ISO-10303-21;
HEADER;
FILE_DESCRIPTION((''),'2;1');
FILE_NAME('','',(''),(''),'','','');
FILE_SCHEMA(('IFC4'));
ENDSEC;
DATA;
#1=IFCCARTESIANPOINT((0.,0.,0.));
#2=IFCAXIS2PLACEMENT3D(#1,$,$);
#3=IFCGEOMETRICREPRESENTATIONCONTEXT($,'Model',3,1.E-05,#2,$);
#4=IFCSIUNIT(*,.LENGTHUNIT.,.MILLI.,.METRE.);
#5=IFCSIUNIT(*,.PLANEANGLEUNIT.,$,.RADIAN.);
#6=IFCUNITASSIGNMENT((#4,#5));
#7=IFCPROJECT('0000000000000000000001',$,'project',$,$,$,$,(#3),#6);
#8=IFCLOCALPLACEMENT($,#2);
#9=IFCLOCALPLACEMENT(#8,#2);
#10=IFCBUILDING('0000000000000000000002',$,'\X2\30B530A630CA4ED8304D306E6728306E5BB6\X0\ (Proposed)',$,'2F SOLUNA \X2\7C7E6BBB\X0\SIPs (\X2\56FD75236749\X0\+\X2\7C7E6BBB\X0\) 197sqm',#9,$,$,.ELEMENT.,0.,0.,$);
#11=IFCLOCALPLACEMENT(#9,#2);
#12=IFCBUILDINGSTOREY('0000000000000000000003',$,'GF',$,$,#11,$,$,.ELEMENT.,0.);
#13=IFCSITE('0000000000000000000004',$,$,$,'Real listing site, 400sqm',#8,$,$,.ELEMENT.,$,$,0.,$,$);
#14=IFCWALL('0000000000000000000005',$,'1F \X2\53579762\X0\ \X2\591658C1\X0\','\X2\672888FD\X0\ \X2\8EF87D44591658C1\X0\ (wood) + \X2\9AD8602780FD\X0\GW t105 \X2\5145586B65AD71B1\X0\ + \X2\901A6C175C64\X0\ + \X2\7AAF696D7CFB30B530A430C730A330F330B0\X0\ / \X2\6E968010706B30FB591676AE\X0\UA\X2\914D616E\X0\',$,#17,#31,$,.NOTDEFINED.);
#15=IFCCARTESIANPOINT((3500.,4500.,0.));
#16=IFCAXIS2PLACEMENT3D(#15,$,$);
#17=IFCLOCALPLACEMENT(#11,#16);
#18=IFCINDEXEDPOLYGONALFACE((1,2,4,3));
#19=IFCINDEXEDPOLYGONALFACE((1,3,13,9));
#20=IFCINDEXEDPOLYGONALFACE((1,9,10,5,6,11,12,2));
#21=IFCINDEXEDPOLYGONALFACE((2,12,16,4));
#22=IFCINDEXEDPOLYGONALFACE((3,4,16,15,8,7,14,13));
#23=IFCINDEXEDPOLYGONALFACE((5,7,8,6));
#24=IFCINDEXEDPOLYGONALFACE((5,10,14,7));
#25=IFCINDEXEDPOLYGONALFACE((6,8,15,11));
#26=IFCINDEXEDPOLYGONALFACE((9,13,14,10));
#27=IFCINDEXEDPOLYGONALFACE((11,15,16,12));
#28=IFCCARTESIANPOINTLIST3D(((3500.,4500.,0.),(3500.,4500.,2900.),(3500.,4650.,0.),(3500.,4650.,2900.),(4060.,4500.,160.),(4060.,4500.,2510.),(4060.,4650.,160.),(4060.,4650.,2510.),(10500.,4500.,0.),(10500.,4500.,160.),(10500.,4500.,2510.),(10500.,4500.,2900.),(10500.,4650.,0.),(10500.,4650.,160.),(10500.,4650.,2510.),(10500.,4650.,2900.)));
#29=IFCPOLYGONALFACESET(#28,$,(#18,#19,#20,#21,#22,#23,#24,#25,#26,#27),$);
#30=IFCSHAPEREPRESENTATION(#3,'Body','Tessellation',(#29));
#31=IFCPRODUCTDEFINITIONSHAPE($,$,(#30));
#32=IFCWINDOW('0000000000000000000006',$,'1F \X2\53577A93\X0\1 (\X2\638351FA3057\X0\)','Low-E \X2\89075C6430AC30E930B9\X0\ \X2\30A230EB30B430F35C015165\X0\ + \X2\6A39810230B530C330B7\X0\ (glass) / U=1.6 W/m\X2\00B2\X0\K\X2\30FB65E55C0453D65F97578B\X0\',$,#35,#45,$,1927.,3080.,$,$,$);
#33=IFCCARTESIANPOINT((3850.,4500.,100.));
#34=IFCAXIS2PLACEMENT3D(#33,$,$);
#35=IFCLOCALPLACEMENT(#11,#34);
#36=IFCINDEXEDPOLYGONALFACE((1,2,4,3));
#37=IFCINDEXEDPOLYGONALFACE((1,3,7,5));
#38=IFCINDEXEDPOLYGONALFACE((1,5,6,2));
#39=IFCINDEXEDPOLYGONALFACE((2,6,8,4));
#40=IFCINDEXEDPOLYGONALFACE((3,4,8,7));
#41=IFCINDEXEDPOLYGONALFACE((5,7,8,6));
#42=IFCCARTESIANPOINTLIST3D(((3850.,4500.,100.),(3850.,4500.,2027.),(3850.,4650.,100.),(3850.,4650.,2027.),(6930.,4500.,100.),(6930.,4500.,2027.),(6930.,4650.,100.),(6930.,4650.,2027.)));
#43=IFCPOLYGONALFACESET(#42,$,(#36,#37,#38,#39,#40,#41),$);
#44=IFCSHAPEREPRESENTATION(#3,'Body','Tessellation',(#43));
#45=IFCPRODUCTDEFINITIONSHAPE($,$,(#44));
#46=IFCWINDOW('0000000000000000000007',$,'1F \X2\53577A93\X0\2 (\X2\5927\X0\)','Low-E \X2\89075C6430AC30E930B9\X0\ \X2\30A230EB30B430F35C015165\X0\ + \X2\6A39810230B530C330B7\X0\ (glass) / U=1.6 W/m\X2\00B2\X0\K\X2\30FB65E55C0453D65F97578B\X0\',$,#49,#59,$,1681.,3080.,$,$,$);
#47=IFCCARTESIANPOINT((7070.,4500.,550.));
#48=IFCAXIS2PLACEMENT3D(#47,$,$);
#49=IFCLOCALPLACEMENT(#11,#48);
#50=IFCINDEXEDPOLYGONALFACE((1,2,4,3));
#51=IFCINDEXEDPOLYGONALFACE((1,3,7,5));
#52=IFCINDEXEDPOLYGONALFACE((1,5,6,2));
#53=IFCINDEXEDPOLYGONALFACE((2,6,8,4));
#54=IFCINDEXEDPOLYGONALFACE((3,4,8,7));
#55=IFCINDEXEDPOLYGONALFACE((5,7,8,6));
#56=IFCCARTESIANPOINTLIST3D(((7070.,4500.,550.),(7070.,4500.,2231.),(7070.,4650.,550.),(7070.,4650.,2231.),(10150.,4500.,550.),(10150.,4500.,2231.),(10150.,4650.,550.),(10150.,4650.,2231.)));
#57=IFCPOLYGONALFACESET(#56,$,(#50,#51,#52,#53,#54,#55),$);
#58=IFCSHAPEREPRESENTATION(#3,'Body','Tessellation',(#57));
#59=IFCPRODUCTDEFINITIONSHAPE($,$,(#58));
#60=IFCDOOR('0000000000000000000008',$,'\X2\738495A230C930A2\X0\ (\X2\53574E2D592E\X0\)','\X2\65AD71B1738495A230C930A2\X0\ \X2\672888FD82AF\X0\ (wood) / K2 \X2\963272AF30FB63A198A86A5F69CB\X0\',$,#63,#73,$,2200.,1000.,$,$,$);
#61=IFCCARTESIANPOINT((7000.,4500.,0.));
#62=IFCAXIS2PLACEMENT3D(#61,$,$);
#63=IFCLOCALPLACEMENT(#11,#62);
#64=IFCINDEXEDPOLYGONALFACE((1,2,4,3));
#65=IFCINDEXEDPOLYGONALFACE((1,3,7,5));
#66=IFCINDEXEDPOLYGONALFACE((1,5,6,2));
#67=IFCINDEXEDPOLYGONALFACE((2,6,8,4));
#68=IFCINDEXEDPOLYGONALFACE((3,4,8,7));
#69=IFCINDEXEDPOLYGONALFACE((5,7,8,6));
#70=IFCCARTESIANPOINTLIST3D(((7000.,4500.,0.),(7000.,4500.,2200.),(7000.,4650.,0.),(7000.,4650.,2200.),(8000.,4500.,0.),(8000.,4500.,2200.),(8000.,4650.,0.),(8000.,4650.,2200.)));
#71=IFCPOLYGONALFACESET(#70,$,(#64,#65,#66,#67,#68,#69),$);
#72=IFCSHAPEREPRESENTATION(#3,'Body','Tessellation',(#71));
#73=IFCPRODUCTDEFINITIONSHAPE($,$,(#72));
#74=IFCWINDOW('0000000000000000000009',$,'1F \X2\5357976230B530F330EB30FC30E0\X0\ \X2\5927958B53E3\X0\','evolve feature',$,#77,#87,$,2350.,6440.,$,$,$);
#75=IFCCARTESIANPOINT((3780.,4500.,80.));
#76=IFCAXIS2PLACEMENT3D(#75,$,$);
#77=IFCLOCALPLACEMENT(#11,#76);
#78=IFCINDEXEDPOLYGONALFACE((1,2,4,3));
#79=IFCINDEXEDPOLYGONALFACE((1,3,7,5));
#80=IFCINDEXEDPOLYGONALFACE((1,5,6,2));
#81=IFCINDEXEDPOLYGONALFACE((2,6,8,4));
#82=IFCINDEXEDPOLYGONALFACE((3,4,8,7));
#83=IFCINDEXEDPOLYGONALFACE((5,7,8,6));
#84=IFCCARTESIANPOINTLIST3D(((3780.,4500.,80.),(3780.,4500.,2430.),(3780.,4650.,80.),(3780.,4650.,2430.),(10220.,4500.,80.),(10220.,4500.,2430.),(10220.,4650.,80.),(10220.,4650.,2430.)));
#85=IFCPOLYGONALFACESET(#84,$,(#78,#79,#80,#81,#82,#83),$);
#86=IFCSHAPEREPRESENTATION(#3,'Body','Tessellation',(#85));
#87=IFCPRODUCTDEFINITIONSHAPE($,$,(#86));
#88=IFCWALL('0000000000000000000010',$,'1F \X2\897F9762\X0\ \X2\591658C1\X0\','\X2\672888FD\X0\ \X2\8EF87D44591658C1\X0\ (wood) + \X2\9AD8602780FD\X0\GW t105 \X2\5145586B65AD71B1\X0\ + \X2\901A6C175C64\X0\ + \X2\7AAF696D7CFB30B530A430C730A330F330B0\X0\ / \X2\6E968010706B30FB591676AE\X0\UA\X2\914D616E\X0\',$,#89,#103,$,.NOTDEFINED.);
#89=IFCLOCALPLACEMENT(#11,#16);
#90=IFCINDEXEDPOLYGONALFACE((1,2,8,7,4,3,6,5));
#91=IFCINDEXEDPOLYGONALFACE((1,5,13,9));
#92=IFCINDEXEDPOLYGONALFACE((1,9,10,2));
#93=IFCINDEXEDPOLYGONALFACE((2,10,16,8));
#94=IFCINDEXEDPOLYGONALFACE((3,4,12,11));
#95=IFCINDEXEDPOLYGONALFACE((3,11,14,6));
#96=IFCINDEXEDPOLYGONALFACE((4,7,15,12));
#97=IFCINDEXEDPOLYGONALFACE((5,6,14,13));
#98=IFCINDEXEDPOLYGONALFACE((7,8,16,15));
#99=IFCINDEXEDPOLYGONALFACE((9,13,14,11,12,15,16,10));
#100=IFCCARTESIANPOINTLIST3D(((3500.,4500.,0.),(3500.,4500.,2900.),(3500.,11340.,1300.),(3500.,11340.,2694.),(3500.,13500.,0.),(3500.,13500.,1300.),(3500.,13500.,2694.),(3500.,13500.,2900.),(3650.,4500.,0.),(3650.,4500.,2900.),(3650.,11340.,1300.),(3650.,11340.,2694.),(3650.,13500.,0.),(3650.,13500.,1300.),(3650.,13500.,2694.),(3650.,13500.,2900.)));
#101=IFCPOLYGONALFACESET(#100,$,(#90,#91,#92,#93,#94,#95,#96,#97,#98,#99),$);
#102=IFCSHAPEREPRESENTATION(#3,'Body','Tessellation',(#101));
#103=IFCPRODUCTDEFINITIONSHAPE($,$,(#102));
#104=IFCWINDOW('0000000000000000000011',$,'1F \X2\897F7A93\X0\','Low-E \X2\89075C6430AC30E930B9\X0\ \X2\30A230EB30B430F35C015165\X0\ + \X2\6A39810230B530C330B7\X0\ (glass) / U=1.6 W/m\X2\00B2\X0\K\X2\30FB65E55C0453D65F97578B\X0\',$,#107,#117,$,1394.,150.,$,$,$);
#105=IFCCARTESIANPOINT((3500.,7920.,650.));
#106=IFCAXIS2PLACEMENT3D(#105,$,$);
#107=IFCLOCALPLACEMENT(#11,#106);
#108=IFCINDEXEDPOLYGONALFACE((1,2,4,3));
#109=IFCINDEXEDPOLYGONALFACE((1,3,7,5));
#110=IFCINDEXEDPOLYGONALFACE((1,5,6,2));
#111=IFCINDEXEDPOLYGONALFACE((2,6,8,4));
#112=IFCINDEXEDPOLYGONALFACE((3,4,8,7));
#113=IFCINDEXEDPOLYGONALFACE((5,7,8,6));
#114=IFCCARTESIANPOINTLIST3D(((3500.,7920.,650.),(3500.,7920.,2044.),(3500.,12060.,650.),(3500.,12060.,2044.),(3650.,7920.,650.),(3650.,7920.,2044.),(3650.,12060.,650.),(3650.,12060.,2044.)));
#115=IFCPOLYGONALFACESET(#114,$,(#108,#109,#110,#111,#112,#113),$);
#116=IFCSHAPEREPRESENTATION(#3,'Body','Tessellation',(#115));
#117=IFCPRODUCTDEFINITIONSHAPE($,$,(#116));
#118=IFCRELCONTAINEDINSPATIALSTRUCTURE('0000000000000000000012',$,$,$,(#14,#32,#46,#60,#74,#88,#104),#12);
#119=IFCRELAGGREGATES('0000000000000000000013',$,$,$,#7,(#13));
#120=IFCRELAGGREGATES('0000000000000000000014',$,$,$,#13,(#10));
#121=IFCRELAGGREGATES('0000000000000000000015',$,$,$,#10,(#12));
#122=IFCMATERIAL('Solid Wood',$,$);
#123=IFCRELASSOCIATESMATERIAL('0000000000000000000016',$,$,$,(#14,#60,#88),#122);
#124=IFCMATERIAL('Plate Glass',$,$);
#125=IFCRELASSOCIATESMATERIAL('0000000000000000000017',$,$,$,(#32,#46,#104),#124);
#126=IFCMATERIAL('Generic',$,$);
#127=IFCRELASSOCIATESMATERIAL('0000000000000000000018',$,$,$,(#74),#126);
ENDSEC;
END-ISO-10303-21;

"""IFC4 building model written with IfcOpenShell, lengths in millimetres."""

from ifc_helpers import new_model, si_unit, frame, frame_2d, origin, place, context, project, spatial, rectangle, extrude, material, element, fill, save


model = new_model("IFC4")

# Units and contexts
model_context = context("Model", 3, precision=1e-05, world=origin())
ifc_project = project(units=[si_unit("LENGTHUNIT", "METRE", prefix="MILLI"), si_unit("PLANEANGLEUNIT", "RADIAN")], contexts=[model_context])

# Site, building, storey
site_placement = place(None, origin())
site = spatial("IfcSite", under=ifc_project, at=site_placement, ObjectType="Real listing site, 400sqm", CompositionType="ELEMENT", RefElevation=0.0)
building_placement = place(site_placement, origin())
building = spatial("IfcBuilding", under=site, at=building_placement, Name="サウナ付きの木の家 (Proposed)", ObjectType="2F SOLUNA 籾殻SIPs (国産杉+籾殻) 197sqm", CompositionType="ELEMENT", ElevationOfRefHeight=0.0, ElevationOfTerrain=0.0)
storey_placement = place(building_placement, origin())
storey = spatial("IfcBuildingStorey", under=building, at=storey_placement, Name="GF", CompositionType="ELEMENT", Elevation=0.0)

# Shared definitions
ifc_material_1 = material(Name="Solid Wood")

# Wall, openings, windows, door
wall_1_placement = place(storey_placement, frame((3500.0, 4500.0, 0.0)))
wall_1 = element("IfcWall", 1, at=wall_1_placement, inside=storey, material=ifc_material_1, Name="1F 南面 外壁", Description="木製 軸組外壁 (wood) + 高性能GW t105 充填断熱 + 通気層 + 窯業系サイディング / 準耐火・外皮UA配慮", PredefinedType="NOTDEFINED", context=model_context, shape_type="SweptSolid", body=[
    extrude(rectangle(XDim=7000.0, YDim=150.0, at=frame_2d((3500.0, 75.0))), frame((3500.0, 4500.0, 0.0)), (0.0, 0.0, 1.0), 2900.0),
])
opening_1_placement = place(storey_placement, frame((3850.0, 4500.0, 100.0)))
opening_1 = element("IfcOpeningElement", 2, at=opening_1_placement, cuts=wall_1, PredefinedType="NOTDEFINED", context=model_context, shape_type="SweptSolid", body=[
    extrude(rectangle(XDim=3080.0, YDim=150.0, at=frame_2d((1540.0, 75.0))), frame((3850.0, 4500.0, 100.0)), (0.0, 0.0, 1.0), 1927.0),
])
opening_2_placement = place(storey_placement, frame((7070.0, 4500.0, 550.0)))
opening_2 = element("IfcOpeningElement", 3, at=opening_2_placement, cuts=wall_1, PredefinedType="NOTDEFINED", context=model_context, shape_type="SweptSolid", body=[
    extrude(rectangle(XDim=3080.0, YDim=150.0, at=frame_2d((1540.0, 75.0))), frame((7070.0, 4500.0, 550.0)), (0.0, 0.0, 1.0), 1681.0),
])
opening_3_placement = place(storey_placement, frame((7000.0, 4500.0, 0.0)))
opening_3 = element("IfcOpeningElement", 4, at=opening_3_placement, cuts=wall_1, PredefinedType="NOTDEFINED", context=model_context, shape_type="SweptSolid", body=[
    extrude(rectangle(XDim=1000.0, YDim=150.0, at=frame_2d((500.0, 75.0))), frame((7000.0, 4500.0, 0.0)), (0.0, 0.0, 1.0), 2200.0),
])
opening_4_placement = place(storey_placement, frame((3780.0, 4500.0, 80.0)))
opening_4 = element("IfcOpeningElement", 5, at=opening_4_placement, cuts=wall_1, PredefinedType="NOTDEFINED", context=model_context, shape_type="SweptSolid", body=[
    extrude(rectangle(XDim=6440.0, YDim=150.0, at=frame_2d((3220.0, 75.0))), frame((3780.0, 4500.0, 80.0)), (0.0, 0.0, 1.0), 2350.0),
])
ifc_material_2 = material(Name="Plate Glass")
window_1_placement = place(storey_placement, frame((3850.0, 4500.0, 100.0)))
window_1 = element("IfcWindow", 6, at=window_1_placement, inside=storey, material=ifc_material_2, Name="1F 南窓1 (掃出し)", Description="Low-E 複層ガラス アルゴン封入 + 樹脂サッシ (glass) / U=1.6 W/m²K・日射取得型", OverallHeight=1927.0, OverallWidth=3080.0, context=model_context, shape_type="SweptSolid", body=[
    extrude(rectangle(XDim=3080.0, YDim=150.0, at=frame_2d((1540.0, 75.0))), frame((3850.0, 4500.0, 100.0)), (0.0, 0.0, 1.0), 1927.0),
])
fill(opening_1, window_1)
window_2_placement = place(storey_placement, frame((7070.0, 4500.0, 550.0)))
window_2 = element("IfcWindow", 7, at=window_2_placement, inside=storey, material=ifc_material_2, Name="1F 南窓2 (大)", Description="Low-E 複層ガラス アルゴン封入 + 樹脂サッシ (glass) / U=1.6 W/m²K・日射取得型", OverallHeight=1681.0, OverallWidth=3080.0, context=model_context, shape_type="SweptSolid", body=[
    extrude(rectangle(XDim=3080.0, YDim=150.0, at=frame_2d((1540.0, 75.0))), frame((7070.0, 4500.0, 550.0)), (0.0, 0.0, 1.0), 1681.0),
])
fill(opening_2, window_2)
door_placement = place(storey_placement, frame((7000.0, 4500.0, 0.0)))
door = element("IfcDoor", 8, at=door_placement, inside=storey, material=ifc_material_1, Name="玄関ドア (南中央)", Description="断熱玄関ドア 木製芯 (wood) / K2 防犯・採風機構", OverallHeight=2200.0, OverallWidth=1000.0, context=model_context, shape_type="SweptSolid", body=[
    extrude(rectangle(XDim=1000.0, YDim=150.0, at=frame_2d((500.0, 75.0))), frame((7000.0, 4500.0, 0.0)), (0.0, 0.0, 1.0), 2200.0),
])
fill(opening_3, door)
ifc_material_3 = material(Name="Generic")
window_3_placement = place(storey_placement, frame((3780.0, 4500.0, 80.0)))
window_3 = element("IfcWindow", 9, at=window_3_placement, inside=storey, material=ifc_material_3, Name="1F 南面サンルーム 大開口", Description="evolve feature", OverallHeight=2350.0, OverallWidth=6440.0, context=model_context, shape_type="SweptSolid", body=[
    extrude(rectangle(XDim=6440.0, YDim=150.0, at=frame_2d((3220.0, 75.0))), frame((3780.0, 4500.0, 80.0)), (0.0, 0.0, 1.0), 2350.0),
])
fill(opening_4, window_3)

# Wall, opening, window
wall_2_placement = place(storey_placement, frame((3500.0, 4500.0, 0.0)))
wall_2 = element("IfcWall", 10, at=wall_2_placement, inside=storey, material=ifc_material_1, Name="1F 西面 外壁", Description="木製 軸組外壁 (wood) + 高性能GW t105 充填断熱 + 通気層 + 窯業系サイディング / 準耐火・外皮UA配慮", PredefinedType="NOTDEFINED", context=model_context, shape_type="SweptSolid", body=[
    extrude(rectangle(XDim=150.0, YDim=9000.0, at=frame_2d((75.0, 4500.0))), frame((3500.0, 4500.0, 0.0)), (0.0, 0.0, 1.0), 2900.0),
])
opening_5_placement = place(storey_placement, frame((3500.0, 7920.0, 650.0)))
opening_5 = element("IfcOpeningElement", 11, at=opening_5_placement, cuts=wall_2, PredefinedType="NOTDEFINED", context=model_context, shape_type="SweptSolid", body=[
    extrude(rectangle(XDim=150.0, YDim=4140.0, at=frame_2d((75.0, 2070.0))), frame((3500.0, 7920.0, 650.0)), (0.0, 0.0, 1.0), 1394.0),
])
window_4_placement = place(storey_placement, frame((3500.0, 7920.0, 650.0)))
window_4 = element("IfcWindow", 12, at=window_4_placement, inside=storey, material=ifc_material_2, Name="1F 西窓", Description="Low-E 複層ガラス アルゴン封入 + 樹脂サッシ (glass) / U=1.6 W/m²K・日射取得型", OverallHeight=1394.0, OverallWidth=150.0, context=model_context, shape_type="SweptSolid", body=[
    extrude(rectangle(XDim=150.0, YDim=4140.0, at=frame_2d((75.0, 2070.0))), frame((3500.0, 7920.0, 650.0)), (0.0, 0.0, 1.0), 1394.0),
])
fill(opening_5, window_4)

save(model, "model.ifc")
